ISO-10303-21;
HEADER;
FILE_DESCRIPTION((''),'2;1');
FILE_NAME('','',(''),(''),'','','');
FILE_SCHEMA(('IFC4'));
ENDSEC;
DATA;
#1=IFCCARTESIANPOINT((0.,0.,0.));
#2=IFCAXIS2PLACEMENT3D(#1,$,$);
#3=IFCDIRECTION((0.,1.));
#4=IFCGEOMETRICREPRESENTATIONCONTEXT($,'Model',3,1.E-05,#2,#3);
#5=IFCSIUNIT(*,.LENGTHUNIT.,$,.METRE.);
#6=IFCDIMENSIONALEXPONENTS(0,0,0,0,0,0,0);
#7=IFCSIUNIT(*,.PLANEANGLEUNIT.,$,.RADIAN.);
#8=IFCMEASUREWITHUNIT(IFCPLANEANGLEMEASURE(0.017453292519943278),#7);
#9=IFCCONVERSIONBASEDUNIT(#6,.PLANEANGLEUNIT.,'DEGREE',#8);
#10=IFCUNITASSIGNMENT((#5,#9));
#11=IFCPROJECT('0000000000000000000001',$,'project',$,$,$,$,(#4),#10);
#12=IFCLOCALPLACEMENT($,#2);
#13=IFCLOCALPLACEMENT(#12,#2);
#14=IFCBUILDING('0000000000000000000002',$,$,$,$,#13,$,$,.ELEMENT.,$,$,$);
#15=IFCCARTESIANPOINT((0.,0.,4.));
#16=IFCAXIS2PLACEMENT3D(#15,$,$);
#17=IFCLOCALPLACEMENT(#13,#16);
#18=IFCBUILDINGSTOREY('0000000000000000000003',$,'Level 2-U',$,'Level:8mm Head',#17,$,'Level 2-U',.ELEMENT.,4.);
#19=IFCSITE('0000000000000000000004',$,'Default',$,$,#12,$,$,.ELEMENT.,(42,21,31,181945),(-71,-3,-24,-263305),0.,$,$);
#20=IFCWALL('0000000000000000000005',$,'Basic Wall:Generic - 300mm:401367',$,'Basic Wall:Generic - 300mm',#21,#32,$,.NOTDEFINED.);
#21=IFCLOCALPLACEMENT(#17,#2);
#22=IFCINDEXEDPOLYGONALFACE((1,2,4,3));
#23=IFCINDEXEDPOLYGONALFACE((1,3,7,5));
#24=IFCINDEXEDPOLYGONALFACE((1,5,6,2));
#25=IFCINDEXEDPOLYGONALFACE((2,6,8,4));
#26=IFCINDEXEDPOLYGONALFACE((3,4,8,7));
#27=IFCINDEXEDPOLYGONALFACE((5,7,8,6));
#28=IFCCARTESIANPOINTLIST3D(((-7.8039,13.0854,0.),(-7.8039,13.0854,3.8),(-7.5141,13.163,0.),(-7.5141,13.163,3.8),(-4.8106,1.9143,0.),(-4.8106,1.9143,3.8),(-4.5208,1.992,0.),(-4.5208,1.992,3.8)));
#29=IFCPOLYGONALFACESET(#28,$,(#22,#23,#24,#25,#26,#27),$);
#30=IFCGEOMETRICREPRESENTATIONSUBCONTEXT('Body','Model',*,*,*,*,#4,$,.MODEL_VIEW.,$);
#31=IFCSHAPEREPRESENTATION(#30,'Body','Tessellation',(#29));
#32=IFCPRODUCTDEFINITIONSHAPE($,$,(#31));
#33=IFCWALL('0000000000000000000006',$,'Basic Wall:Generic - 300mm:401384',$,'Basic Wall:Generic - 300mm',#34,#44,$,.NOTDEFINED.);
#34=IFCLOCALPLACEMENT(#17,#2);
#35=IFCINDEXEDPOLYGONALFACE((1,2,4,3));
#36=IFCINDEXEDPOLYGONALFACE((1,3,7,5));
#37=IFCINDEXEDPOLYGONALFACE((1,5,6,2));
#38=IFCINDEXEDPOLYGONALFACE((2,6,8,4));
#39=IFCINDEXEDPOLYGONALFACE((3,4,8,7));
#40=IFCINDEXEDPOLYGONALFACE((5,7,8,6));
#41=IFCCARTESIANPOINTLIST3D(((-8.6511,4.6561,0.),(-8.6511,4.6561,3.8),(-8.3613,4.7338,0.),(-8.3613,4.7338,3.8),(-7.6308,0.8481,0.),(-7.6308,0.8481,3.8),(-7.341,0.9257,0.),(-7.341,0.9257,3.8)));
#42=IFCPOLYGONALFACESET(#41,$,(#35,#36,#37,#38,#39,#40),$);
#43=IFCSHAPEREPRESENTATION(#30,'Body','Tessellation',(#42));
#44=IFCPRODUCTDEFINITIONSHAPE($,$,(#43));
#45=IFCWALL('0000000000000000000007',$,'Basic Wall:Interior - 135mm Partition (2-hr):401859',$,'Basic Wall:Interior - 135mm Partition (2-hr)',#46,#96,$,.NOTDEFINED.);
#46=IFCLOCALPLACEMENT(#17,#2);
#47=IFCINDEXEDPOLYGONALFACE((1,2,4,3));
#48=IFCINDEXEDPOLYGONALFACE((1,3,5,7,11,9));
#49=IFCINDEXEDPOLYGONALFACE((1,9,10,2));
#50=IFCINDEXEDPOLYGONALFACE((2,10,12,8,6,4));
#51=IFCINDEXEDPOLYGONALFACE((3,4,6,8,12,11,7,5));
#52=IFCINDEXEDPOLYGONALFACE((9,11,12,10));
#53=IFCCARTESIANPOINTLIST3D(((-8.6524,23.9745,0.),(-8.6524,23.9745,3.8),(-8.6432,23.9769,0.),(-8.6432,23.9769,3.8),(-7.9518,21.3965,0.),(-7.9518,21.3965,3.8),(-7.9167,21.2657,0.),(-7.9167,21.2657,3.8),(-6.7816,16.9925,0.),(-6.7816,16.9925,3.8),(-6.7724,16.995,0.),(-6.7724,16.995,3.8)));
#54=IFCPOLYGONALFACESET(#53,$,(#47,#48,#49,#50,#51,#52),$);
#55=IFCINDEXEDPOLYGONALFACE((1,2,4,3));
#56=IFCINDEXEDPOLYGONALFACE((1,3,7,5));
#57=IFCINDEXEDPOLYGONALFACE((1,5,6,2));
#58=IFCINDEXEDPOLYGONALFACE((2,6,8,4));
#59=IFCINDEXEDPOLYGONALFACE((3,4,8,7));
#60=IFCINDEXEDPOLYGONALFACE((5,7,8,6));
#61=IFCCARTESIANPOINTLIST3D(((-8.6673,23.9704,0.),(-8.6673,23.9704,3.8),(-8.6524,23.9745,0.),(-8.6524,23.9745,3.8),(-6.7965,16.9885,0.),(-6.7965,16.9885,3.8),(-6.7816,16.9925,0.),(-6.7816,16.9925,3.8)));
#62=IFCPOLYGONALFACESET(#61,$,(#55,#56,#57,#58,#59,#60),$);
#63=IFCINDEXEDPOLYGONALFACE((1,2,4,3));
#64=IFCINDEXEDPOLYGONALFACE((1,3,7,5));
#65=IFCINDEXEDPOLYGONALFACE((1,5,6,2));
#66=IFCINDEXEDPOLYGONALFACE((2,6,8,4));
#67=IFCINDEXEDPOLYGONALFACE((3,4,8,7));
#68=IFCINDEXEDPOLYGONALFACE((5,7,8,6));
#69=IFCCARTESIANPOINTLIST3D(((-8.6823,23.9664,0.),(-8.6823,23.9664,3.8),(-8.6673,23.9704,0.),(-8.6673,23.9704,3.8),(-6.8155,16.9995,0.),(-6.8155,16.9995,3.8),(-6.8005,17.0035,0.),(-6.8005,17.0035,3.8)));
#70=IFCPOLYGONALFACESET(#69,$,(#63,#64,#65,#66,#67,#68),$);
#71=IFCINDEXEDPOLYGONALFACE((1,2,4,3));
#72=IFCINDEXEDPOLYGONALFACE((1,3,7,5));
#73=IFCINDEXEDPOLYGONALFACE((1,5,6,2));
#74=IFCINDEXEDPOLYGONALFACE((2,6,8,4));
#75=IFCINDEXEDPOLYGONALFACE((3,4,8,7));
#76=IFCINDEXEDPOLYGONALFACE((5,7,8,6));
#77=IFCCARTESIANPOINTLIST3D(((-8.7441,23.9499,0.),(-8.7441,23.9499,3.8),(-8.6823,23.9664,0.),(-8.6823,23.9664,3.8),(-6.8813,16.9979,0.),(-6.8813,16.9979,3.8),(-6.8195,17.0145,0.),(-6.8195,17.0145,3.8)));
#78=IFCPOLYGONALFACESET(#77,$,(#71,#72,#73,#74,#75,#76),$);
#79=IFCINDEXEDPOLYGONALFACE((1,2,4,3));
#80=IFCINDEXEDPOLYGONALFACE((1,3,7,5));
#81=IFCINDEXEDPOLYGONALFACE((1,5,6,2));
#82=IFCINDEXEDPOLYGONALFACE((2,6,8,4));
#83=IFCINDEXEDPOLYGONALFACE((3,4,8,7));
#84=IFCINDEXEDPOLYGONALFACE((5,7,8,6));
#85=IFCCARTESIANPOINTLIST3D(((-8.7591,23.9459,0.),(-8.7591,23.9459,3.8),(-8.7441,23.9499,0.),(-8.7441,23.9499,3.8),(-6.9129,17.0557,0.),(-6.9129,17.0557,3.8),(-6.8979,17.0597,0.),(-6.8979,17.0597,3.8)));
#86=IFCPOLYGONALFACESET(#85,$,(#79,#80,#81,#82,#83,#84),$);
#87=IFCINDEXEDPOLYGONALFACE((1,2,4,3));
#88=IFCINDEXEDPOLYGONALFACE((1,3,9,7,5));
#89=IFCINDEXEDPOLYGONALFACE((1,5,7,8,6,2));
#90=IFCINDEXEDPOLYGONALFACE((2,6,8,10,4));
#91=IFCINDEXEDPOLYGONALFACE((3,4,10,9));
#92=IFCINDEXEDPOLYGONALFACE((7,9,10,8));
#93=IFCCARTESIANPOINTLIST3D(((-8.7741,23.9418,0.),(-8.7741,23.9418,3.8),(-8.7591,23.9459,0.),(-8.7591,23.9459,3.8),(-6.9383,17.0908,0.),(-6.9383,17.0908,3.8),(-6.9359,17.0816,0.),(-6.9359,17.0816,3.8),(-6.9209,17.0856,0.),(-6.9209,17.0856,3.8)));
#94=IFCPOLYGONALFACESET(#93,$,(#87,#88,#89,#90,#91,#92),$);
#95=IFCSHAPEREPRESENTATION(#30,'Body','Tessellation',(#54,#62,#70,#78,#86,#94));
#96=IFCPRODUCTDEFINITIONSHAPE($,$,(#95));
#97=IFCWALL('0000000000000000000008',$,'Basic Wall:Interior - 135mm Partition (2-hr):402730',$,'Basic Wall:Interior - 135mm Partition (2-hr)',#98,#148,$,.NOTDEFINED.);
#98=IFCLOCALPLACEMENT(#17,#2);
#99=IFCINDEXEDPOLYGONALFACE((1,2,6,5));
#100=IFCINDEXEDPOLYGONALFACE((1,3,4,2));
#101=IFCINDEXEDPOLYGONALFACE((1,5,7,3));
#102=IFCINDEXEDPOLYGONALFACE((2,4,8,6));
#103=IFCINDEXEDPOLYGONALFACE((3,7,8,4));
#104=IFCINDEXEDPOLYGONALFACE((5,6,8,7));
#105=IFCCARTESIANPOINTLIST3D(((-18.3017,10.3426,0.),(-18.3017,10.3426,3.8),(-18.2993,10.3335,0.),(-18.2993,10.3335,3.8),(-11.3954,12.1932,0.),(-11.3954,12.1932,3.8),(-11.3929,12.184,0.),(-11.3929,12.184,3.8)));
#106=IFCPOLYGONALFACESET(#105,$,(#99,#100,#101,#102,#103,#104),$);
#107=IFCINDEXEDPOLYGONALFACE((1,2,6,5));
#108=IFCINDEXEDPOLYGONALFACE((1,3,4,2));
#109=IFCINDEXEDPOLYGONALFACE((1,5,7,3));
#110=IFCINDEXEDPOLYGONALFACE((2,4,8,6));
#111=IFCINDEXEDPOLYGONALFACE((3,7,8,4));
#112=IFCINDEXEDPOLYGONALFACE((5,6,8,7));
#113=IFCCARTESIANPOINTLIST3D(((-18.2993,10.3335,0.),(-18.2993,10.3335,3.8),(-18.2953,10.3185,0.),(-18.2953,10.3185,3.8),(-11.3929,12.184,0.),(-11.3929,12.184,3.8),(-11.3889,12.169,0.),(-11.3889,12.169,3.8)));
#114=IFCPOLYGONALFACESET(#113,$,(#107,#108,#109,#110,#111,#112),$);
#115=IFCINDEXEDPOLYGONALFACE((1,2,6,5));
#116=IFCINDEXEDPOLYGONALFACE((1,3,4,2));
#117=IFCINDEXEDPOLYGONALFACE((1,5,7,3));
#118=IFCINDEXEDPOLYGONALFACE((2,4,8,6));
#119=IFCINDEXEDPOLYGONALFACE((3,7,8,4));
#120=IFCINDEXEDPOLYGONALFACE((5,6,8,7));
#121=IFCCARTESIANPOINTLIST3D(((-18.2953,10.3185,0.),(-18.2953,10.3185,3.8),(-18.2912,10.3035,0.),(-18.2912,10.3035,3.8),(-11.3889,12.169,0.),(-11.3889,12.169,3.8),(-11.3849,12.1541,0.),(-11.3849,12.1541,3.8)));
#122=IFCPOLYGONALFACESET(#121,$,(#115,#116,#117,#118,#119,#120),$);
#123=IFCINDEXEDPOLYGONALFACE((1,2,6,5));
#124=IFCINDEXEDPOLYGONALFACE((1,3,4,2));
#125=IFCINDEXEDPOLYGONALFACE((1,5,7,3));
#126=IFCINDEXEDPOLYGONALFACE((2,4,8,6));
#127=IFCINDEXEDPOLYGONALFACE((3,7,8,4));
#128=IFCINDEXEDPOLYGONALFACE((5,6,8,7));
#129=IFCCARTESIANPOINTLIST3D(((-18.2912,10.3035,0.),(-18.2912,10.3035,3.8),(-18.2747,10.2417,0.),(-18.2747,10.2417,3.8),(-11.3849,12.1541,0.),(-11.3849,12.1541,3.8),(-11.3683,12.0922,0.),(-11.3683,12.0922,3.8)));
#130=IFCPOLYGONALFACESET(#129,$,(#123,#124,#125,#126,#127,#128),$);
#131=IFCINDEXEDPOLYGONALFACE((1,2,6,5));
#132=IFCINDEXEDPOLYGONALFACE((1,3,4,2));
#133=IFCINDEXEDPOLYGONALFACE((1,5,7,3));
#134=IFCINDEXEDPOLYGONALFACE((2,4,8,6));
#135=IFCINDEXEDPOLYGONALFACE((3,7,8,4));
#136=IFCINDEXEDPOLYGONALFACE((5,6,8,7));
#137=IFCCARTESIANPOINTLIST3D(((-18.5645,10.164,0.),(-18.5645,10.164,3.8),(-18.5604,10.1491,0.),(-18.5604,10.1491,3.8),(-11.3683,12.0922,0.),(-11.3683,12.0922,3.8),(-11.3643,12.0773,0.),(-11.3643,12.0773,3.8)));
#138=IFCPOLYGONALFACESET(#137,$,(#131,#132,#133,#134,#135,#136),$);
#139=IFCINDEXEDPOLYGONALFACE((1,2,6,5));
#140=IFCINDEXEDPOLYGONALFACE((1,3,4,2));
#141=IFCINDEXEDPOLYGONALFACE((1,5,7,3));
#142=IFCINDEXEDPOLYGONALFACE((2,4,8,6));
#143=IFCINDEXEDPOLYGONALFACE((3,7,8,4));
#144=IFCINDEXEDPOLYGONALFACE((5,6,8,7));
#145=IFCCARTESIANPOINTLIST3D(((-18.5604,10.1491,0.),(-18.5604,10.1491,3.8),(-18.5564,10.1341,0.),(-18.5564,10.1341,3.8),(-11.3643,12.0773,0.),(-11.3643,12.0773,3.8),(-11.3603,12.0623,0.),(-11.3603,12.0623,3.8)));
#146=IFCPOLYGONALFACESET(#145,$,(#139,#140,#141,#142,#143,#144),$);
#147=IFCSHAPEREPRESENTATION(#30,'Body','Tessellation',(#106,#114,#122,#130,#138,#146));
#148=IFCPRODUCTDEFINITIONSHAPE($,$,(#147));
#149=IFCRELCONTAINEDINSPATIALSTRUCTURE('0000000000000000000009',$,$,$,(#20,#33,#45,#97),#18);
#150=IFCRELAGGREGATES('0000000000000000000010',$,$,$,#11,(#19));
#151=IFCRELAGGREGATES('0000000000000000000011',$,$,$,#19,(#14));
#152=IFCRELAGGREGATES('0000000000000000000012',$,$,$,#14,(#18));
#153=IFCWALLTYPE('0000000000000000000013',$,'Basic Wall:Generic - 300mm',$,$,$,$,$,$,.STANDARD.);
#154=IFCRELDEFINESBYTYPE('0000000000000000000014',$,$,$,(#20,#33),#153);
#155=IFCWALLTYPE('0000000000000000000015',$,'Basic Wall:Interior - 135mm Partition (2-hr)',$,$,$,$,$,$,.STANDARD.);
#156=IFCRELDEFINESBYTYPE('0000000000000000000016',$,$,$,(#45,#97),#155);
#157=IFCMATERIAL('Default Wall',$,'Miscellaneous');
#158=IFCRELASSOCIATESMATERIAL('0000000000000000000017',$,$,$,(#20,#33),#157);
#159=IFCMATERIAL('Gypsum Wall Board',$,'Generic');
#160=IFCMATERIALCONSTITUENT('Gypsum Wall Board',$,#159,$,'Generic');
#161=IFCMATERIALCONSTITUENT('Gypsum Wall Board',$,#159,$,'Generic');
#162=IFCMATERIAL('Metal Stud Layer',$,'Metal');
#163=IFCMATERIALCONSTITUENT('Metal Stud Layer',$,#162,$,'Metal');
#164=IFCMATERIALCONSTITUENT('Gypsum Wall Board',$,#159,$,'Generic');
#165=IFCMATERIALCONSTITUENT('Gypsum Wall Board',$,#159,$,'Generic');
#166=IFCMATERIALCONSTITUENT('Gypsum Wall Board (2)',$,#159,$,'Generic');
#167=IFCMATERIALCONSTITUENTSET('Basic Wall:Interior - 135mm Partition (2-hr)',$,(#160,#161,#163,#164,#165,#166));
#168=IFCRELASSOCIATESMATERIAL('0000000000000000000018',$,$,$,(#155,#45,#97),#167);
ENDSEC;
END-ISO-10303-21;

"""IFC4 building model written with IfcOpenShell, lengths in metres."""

from ifc_helpers import new_model, entity, si_unit, converted_unit, direction, frame, origin, place, context, subcontext, project, spatial, indexed_curve, outline, extrude, material, constituent, constituent_set, type_object, element, save


model = new_model("IFC4")

# Units and contexts
model_context = context("Model", 3, precision=1e-05, world=origin(), true_north=direction((0.0, 1.0)))
body_context = subcontext(model_context, "Body", "Model", "MODEL_VIEW")
ifc_project = project(units=[si_unit("LENGTHUNIT", "METRE"), converted_unit("PLANEANGLEUNIT", "DEGREE", entity("IfcPlaneAngleMeasure", 0.017453292519943278), si_unit("PLANEANGLEUNIT", "RADIAN"), dimensions=[0, 0, 0, 0, 0, 0, 0])], contexts=[model_context])

# Site, building, storey
site_placement = place(None, origin())
site = spatial("IfcSite", under=ifc_project, at=site_placement, Name="Default", CompositionType="ELEMENT", RefLatitude=(42, 21, 31, 181945), RefLongitude=(-71, -3, -24, -263305), RefElevation=0.0)
building_placement = place(site_placement, origin())
building = spatial("IfcBuilding", under=site, at=building_placement, CompositionType="ELEMENT")
storey_placement = place(building_placement, frame((0.0, 0.0, 4.0)))
storey = spatial("IfcBuildingStorey", under=building, at=storey_placement, Name="Level 2-U", ObjectType="Level:8mm Head", LongName="Level 2-U", CompositionType="ELEMENT", Elevation=4.0)

# Walls
ifc_material_1 = material(Name="Default Wall", Category="Miscellaneous")
wall_type_1 = type_object("IfcWallType", Name="Basic Wall:Generic - 300mm", PredefinedType="STANDARD")
wall_1_placement = place(storey_placement, frame((-7.659, 13.1242, 0.0), z_axis=(0.0, 0.0, 1.0), x_axis=(0.258819, -0.965926, 0.0)))
element("IfcWall", 1, at=wall_1_placement, inside=storey, type_object=wall_type_1, material=ifc_material_1, Name="Basic Wall:Generic - 300mm:401367", ObjectType="Basic Wall:Generic - 300mm", PredefinedType="NOTDEFINED", context=body_context, shape_type="SweptSolid", body=[
    extrude(outline(indexed_curve([(11.5651, 0.15), (0.0, 0.15), (0.0, -0.15), (11.5651, -0.15), (11.5651, 0.15)], self_intersect=False)), origin(), (0.0, 0.0, 1.0), 3.8),
])
wall_2_placement = place(storey_placement, frame((-8.5062, 4.6949, 0.0), z_axis=(0.0, 0.0, 1.0), x_axis=(0.258819, -0.965926, 0.0)))
element("IfcWall", 2, at=wall_2_placement, inside=storey, type_object=wall_type_1, material=ifc_material_1, Name="Basic Wall:Generic - 300mm:401384", ObjectType="Basic Wall:Generic - 300mm", PredefinedType="NOTDEFINED", context=body_context, shape_type="SweptSolid", body=[
    extrude(outline(indexed_curve([(3.9424, 0.15), (0.0, 0.15), (0.0, -0.15), (3.9424, -0.15), (3.9424, 0.15)], self_intersect=False)), origin(), (0.0, 0.0, 1.0), 3.8),
])
ifc_material_2 = material(Name="Gypsum Wall Board", Category="Generic")
ifc_constituent_1 = constituent(ifc_material_2, Name="Gypsum Wall Board", Category="Generic")
ifc_constituent_2 = constituent(ifc_material_2, Name="Gypsum Wall Board", Category="Generic")
ifc_material_3 = material(Name="Metal Stud Layer", Category="Metal")
ifc_constituent_3 = constituent(ifc_material_3, Name="Metal Stud Layer", Category="Metal")
ifc_constituent_4 = constituent(ifc_material_2, Name="Gypsum Wall Board", Category="Generic")
ifc_constituent_5 = constituent(ifc_material_2, Name="Gypsum Wall Board", Category="Generic")
ifc_constituent_6 = constituent(ifc_material_2, Name="Gypsum Wall Board (2)", Category="Generic")
ifc_constituent_set_1 = constituent_set(constituents=[ifc_constituent_1, ifc_constituent_2, ifc_constituent_3, ifc_constituent_4, ifc_constituent_5, ifc_constituent_6], Name="Basic Wall:Interior - 135mm Partition (2-hr)")
wall_type_2 = type_object("IfcWallType", Name="Basic Wall:Interior - 135mm Partition (2-hr)", PredefinedType="STANDARD", material=ifc_constituent_set_1)
wall_3_placement = place(storey_placement, frame((-6.8378, 16.9775, 0.0), z_axis=(0.0, 0.0, 1.0), x_axis=(-0.258819, 0.965926, 0.0)))
element("IfcWall", 3, at=wall_3_placement, inside=storey, type_object=wall_type_2, material=ifc_constituent_set_1, Name="Basic Wall:Interior - 135mm Partition (2-hr):401859", ObjectType="Basic Wall:Interior - 135mm Partition (2-hr)", PredefinedType="NOTDEFINED", context=body_context, shape_type="SweptSolid", body=[
    extrude(outline(indexed_curve([(0.5156, -0.0032), (0.6511, -0.0032), (3.3225, -0.0032), (3.3225, 0.0063), (-3.9058, 0.0063), (-3.9058, -0.0032), (0.5156, -0.0032)], self_intersect=False)), frame((3.9058, -0.0646, 0.0)), (0.0, 0.0, 1.0), 3.8),
    extrude(outline(indexed_curve([(-3.6141, -0.0077), (3.6141, -0.0078), (3.6141, 0.0078), (-3.6141, 0.0078), (-3.6141, -0.0077)], self_intersect=False)), frame((3.6141, -0.0505, 0.0)), (0.0, 0.0, 1.0), 3.8),
    extrude(outline(indexed_curve([(-3.6064, -0.0078), (3.6064, -0.0078), (3.6064, 0.0078), (-3.6064, 0.0077), (-3.6064, -0.0078)], self_intersect=False)), frame((3.6219, -0.035, 0.0)), (0.0, 0.0, 1.0), 3.8),
    extrude(outline(indexed_curve([(-3.5986, -0.032), (3.5986, -0.032), (3.5986, 0.032), (-3.5986, 0.032), (-3.5986, -0.032)], self_intersect=False)), frame((3.6296, 0.0048, 0.0)), (0.0, 0.0, 1.0), 3.8),
    extrude(outline(indexed_curve([(-3.5666, -0.0078), (3.5666, -0.0078), (3.5666, 0.0077), (-3.5666, 0.0078), (-3.5666, -0.0078)], self_intersect=False)), frame((3.6616, 0.0445, 0.0)), (0.0, 0.0, 1.0), 3.8),
    extrude(outline(indexed_curve([(2.8333, -0.0062), (2.8428, -0.0062), (2.8428, 0.0093), (-4.2594, 0.0093), (-4.2594, -0.0062), (2.8333, -0.0062)], self_intersect=False)), frame((2.9688, 0.0616, 0.0), z_axis=(0.0, 0.0, 1.0), x_axis=(-1.0, 0.0, 0.0)), (0.0, 0.0, 1.0), 3.8),
])

# Wall
wall_4_placement = place(storey_placement, frame((-11.3778, 12.1277, 0.0), z_axis=(0.0, 0.0, 1.0), x_axis=(-0.965926, -0.258819, 0.0)))
element("IfcWall", 4, at=wall_4_placement, inside=storey, type_object=wall_type_2, material=ifc_constituent_set_1, Name="Basic Wall:Interior - 135mm Partition (2-hr):402730", ObjectType="Basic Wall:Interior - 135mm Partition (2-hr)", PredefinedType="NOTDEFINED", context=body_context, shape_type="SweptSolid", body=[
    extrude(outline(indexed_curve([(-0.0047, -3.575), (0.0048, -3.575), (0.0047, 3.575), (-0.0048, 3.575), (-0.0047, -3.575)], self_intersect=False)), frame((3.575, -0.063, 0.0), z_axis=(0.0, 0.0, 1.0), x_axis=(0.0, 1.0, 0.0)), (0.0, 0.0, 1.0), 3.8),
    extrude(outline(indexed_curve([(-3.575, -0.0077), (3.575, -0.0078), (3.575, 0.0077), (-3.575, 0.0078), (-3.575, -0.0077)], self_intersect=False)), frame((3.575, -0.0505, 0.0)), (0.0, 0.0, 1.0), 3.8),
    extrude(outline(indexed_curve([(-3.575, -0.0078), (3.575, -0.0077), (3.575, 0.0078), (-3.575, 0.0077), (-3.575, -0.0078)], self_intersect=False)), frame((3.575, -0.035, 0.0)), (0.0, 0.0, 1.0), 3.8),
    extrude(outline(indexed_curve([(-3.575, -0.032), (3.575, -0.032), (3.575, 0.032), (-3.575, 0.032), (-3.575, -0.032)], self_intersect=False)), frame((3.575, 0.0048, 0.0)), (0.0, 0.0, 1.0), 3.8),
    extrude(outline(indexed_curve([(-3.725, -0.0078), (3.725, -0.0077), (3.725, 0.0078), (-3.725, 0.0077), (-3.725, -0.0078)], self_intersect=False)), frame((3.725, 0.0445, 0.0)), (0.0, 0.0, 1.0), 3.8),
    extrude(outline(indexed_curve([(-0.0078, -3.725), (0.0077, -3.725), (0.0078, 3.725), (-0.0077, 3.725), (-0.0078, -3.725)], self_intersect=False)), frame((3.725, 0.06, 0.0), z_axis=(0.0, 0.0, 1.0), x_axis=(0.0, -1.0, 0.0)), (0.0, 0.0, 1.0), 3.8),
])

save(model, "model.ifc")
